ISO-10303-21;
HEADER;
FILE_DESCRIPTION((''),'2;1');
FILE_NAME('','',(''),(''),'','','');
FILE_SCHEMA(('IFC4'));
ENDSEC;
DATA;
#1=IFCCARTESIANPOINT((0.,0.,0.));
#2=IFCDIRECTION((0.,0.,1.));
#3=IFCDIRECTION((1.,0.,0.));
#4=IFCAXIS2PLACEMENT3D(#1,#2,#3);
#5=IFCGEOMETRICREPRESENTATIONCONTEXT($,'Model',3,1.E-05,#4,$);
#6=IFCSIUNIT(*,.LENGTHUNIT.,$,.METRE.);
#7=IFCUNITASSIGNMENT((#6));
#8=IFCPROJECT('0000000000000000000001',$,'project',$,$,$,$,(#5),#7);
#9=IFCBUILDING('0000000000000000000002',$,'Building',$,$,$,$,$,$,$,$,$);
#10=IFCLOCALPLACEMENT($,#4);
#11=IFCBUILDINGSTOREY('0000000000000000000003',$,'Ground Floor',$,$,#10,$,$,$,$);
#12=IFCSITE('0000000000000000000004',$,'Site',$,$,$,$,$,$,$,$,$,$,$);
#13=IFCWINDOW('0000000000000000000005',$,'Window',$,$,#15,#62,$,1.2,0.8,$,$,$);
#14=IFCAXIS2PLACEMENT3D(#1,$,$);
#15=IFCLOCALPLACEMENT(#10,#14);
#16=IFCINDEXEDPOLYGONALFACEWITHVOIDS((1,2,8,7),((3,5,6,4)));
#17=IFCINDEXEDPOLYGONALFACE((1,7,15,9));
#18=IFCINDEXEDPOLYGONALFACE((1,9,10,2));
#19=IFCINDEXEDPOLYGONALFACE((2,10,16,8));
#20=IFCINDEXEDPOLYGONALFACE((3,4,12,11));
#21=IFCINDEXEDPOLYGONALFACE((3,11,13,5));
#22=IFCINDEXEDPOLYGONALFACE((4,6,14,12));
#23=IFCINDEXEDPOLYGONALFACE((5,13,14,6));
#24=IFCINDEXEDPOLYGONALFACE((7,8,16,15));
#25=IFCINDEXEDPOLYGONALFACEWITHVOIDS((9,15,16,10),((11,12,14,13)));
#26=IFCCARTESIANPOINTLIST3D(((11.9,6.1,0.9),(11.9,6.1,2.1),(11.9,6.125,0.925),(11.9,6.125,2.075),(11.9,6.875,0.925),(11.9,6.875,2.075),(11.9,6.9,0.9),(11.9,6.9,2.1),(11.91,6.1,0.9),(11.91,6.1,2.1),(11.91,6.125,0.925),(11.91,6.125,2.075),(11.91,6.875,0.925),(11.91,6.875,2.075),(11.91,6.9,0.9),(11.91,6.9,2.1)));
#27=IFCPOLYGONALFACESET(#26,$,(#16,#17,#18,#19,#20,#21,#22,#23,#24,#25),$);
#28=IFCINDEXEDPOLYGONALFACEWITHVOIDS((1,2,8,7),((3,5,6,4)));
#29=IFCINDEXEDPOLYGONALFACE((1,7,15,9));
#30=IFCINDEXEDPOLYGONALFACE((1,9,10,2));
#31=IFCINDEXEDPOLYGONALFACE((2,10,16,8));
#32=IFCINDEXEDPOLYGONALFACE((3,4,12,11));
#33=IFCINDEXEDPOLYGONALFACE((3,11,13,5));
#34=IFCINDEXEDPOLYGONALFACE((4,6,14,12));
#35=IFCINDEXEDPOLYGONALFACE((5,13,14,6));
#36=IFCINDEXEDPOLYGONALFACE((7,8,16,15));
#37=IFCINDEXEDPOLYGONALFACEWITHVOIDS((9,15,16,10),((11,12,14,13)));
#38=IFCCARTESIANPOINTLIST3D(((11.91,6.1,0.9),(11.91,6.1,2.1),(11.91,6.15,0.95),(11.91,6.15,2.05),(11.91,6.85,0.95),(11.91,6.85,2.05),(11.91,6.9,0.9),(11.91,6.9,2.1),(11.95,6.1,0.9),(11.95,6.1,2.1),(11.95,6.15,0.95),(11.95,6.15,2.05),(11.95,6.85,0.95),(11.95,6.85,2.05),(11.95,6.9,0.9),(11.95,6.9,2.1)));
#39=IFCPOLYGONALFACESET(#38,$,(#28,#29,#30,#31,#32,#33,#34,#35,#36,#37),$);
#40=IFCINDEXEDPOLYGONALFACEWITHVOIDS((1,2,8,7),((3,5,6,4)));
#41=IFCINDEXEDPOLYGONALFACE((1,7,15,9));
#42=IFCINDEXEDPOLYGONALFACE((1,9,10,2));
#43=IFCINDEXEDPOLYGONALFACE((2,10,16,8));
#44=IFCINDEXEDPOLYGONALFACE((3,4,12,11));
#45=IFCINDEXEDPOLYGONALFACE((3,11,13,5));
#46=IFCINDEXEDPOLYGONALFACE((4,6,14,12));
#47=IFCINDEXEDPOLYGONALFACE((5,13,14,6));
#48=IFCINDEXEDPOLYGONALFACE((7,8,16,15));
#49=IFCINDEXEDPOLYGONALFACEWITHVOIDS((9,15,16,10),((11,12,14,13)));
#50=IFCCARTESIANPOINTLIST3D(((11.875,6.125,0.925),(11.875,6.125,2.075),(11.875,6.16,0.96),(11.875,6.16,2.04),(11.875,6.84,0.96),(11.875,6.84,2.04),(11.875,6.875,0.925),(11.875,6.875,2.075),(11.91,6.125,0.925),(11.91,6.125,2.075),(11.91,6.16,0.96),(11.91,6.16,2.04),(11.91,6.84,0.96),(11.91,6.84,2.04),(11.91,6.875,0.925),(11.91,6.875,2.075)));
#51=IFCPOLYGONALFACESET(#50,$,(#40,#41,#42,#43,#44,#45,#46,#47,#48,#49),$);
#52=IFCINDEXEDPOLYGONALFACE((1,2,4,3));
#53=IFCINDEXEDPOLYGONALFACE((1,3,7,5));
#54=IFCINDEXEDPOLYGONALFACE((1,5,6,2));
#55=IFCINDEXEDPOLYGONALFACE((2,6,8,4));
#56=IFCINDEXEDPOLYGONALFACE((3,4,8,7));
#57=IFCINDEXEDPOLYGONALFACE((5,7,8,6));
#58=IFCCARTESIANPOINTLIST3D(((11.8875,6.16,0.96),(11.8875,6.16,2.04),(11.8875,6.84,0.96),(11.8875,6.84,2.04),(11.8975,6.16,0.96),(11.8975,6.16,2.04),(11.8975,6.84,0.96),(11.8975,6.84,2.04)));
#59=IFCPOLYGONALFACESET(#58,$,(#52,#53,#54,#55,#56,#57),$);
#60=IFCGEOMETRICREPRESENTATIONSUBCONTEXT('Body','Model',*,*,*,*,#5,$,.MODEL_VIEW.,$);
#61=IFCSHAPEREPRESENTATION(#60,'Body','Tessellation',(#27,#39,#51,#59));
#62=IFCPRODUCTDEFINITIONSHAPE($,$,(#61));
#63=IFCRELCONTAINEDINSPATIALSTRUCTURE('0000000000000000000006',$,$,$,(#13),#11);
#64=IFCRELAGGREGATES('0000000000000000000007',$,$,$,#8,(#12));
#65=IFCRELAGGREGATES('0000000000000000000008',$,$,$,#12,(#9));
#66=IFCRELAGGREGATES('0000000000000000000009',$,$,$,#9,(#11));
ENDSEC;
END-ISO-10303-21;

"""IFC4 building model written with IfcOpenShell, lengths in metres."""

from ifc_helpers import new_model, si_unit, frame, origin_with_axes, place, context, subcontext, project, spatial, line, indexed_curve, outline, extrude, element, save


model = new_model("IFC4")

# Units and contexts
model_context = context("Model", 3, precision=1e-05, world=origin_with_axes())
body_context = subcontext(model_context, "Body", "Model", "MODEL_VIEW")
ifc_project = project(units=[si_unit("LENGTHUNIT", "METRE")], contexts=[model_context])

# Site, building, storey
site = spatial("IfcSite", under=ifc_project, Name="Site")
building = spatial("IfcBuilding", under=site, Name="Building")
storey_placement = place(None, origin_with_axes())
storey = spatial("IfcBuildingStorey", under=building, at=storey_placement, Name="Ground Floor")

# Window
window_1_placement = place(storey_placement, frame((12.0, 6.1, 0.9), z_axis=(0.0, 0.0, 1.0), x_axis=(0.0, 1.0, 0.0)))
element("IfcWindow", 1, at=window_1_placement, inside=storey, Name="Window", OverallHeight=1.2, OverallWidth=0.8, context=body_context, shape_type="SweptSolid", body=[
    extrude(outline(indexed_curve([(0.0, 0.0), (0.8, 0.0), (0.8, 1.2), (0.0, 1.2)], segments=[line(1, 2, 3, 4, 1)]), holes=[indexed_curve([(0.025, 0.025), (0.775, 0.025), (0.775, 1.175), (0.025, 1.175)], segments=[line(1, 2, 3, 4, 1)])]), frame((0.0, 0.09, 0.0), z_axis=(0.0, -1.0, 0.0), x_axis=(1.0, 0.0, 0.0)), (0.0, 0.0, -1.0), 0.01),
    extrude(outline(indexed_curve([(0.0, 0.0), (0.8, 0.0), (0.8, 1.2), (0.0, 1.2)], segments=[line(1, 2, 3, 4, 1)]), holes=[indexed_curve([(0.05, 0.05), (0.75, 0.05), (0.75, 1.15), (0.05, 1.15)], segments=[line(1, 2, 3, 4, 1)])]), frame((0.0, 0.05, 0.0), z_axis=(0.0, -1.0, 0.0), x_axis=(1.0, 0.0, 0.0)), (0.0, 0.0, -1.0), 0.04),
    extrude(outline(indexed_curve([(0.0, 0.0), (0.75, 0.0), (0.75, 1.15), (0.0, 1.15)], segments=[line(1, 2, 3, 4, 1)]), holes=[indexed_curve([(0.035, 0.035), (0.715, 0.035), (0.715, 1.115), (0.035, 1.115)], segments=[line(1, 2, 3, 4, 1)])]), frame((0.025, 0.09, 0.025), z_axis=(0.0, -1.0, 0.0), x_axis=(1.0, 0.0, 0.0)), (0.0, 0.0, -1.0), 0.035),
    extrude(outline(indexed_curve([(0.035, 0.035), (0.715, 0.035), (0.715, 1.115), (0.035, 1.115)], segments=[line(1, 2, 3, 4, 1)])), frame((0.025, 0.1025, 0.025), z_axis=(0.0, -1.0, 0.0), x_axis=(1.0, 0.0, 0.0)), (0.0, 0.0, -1.0), 0.01),
])

save(model, "model.ifc")
